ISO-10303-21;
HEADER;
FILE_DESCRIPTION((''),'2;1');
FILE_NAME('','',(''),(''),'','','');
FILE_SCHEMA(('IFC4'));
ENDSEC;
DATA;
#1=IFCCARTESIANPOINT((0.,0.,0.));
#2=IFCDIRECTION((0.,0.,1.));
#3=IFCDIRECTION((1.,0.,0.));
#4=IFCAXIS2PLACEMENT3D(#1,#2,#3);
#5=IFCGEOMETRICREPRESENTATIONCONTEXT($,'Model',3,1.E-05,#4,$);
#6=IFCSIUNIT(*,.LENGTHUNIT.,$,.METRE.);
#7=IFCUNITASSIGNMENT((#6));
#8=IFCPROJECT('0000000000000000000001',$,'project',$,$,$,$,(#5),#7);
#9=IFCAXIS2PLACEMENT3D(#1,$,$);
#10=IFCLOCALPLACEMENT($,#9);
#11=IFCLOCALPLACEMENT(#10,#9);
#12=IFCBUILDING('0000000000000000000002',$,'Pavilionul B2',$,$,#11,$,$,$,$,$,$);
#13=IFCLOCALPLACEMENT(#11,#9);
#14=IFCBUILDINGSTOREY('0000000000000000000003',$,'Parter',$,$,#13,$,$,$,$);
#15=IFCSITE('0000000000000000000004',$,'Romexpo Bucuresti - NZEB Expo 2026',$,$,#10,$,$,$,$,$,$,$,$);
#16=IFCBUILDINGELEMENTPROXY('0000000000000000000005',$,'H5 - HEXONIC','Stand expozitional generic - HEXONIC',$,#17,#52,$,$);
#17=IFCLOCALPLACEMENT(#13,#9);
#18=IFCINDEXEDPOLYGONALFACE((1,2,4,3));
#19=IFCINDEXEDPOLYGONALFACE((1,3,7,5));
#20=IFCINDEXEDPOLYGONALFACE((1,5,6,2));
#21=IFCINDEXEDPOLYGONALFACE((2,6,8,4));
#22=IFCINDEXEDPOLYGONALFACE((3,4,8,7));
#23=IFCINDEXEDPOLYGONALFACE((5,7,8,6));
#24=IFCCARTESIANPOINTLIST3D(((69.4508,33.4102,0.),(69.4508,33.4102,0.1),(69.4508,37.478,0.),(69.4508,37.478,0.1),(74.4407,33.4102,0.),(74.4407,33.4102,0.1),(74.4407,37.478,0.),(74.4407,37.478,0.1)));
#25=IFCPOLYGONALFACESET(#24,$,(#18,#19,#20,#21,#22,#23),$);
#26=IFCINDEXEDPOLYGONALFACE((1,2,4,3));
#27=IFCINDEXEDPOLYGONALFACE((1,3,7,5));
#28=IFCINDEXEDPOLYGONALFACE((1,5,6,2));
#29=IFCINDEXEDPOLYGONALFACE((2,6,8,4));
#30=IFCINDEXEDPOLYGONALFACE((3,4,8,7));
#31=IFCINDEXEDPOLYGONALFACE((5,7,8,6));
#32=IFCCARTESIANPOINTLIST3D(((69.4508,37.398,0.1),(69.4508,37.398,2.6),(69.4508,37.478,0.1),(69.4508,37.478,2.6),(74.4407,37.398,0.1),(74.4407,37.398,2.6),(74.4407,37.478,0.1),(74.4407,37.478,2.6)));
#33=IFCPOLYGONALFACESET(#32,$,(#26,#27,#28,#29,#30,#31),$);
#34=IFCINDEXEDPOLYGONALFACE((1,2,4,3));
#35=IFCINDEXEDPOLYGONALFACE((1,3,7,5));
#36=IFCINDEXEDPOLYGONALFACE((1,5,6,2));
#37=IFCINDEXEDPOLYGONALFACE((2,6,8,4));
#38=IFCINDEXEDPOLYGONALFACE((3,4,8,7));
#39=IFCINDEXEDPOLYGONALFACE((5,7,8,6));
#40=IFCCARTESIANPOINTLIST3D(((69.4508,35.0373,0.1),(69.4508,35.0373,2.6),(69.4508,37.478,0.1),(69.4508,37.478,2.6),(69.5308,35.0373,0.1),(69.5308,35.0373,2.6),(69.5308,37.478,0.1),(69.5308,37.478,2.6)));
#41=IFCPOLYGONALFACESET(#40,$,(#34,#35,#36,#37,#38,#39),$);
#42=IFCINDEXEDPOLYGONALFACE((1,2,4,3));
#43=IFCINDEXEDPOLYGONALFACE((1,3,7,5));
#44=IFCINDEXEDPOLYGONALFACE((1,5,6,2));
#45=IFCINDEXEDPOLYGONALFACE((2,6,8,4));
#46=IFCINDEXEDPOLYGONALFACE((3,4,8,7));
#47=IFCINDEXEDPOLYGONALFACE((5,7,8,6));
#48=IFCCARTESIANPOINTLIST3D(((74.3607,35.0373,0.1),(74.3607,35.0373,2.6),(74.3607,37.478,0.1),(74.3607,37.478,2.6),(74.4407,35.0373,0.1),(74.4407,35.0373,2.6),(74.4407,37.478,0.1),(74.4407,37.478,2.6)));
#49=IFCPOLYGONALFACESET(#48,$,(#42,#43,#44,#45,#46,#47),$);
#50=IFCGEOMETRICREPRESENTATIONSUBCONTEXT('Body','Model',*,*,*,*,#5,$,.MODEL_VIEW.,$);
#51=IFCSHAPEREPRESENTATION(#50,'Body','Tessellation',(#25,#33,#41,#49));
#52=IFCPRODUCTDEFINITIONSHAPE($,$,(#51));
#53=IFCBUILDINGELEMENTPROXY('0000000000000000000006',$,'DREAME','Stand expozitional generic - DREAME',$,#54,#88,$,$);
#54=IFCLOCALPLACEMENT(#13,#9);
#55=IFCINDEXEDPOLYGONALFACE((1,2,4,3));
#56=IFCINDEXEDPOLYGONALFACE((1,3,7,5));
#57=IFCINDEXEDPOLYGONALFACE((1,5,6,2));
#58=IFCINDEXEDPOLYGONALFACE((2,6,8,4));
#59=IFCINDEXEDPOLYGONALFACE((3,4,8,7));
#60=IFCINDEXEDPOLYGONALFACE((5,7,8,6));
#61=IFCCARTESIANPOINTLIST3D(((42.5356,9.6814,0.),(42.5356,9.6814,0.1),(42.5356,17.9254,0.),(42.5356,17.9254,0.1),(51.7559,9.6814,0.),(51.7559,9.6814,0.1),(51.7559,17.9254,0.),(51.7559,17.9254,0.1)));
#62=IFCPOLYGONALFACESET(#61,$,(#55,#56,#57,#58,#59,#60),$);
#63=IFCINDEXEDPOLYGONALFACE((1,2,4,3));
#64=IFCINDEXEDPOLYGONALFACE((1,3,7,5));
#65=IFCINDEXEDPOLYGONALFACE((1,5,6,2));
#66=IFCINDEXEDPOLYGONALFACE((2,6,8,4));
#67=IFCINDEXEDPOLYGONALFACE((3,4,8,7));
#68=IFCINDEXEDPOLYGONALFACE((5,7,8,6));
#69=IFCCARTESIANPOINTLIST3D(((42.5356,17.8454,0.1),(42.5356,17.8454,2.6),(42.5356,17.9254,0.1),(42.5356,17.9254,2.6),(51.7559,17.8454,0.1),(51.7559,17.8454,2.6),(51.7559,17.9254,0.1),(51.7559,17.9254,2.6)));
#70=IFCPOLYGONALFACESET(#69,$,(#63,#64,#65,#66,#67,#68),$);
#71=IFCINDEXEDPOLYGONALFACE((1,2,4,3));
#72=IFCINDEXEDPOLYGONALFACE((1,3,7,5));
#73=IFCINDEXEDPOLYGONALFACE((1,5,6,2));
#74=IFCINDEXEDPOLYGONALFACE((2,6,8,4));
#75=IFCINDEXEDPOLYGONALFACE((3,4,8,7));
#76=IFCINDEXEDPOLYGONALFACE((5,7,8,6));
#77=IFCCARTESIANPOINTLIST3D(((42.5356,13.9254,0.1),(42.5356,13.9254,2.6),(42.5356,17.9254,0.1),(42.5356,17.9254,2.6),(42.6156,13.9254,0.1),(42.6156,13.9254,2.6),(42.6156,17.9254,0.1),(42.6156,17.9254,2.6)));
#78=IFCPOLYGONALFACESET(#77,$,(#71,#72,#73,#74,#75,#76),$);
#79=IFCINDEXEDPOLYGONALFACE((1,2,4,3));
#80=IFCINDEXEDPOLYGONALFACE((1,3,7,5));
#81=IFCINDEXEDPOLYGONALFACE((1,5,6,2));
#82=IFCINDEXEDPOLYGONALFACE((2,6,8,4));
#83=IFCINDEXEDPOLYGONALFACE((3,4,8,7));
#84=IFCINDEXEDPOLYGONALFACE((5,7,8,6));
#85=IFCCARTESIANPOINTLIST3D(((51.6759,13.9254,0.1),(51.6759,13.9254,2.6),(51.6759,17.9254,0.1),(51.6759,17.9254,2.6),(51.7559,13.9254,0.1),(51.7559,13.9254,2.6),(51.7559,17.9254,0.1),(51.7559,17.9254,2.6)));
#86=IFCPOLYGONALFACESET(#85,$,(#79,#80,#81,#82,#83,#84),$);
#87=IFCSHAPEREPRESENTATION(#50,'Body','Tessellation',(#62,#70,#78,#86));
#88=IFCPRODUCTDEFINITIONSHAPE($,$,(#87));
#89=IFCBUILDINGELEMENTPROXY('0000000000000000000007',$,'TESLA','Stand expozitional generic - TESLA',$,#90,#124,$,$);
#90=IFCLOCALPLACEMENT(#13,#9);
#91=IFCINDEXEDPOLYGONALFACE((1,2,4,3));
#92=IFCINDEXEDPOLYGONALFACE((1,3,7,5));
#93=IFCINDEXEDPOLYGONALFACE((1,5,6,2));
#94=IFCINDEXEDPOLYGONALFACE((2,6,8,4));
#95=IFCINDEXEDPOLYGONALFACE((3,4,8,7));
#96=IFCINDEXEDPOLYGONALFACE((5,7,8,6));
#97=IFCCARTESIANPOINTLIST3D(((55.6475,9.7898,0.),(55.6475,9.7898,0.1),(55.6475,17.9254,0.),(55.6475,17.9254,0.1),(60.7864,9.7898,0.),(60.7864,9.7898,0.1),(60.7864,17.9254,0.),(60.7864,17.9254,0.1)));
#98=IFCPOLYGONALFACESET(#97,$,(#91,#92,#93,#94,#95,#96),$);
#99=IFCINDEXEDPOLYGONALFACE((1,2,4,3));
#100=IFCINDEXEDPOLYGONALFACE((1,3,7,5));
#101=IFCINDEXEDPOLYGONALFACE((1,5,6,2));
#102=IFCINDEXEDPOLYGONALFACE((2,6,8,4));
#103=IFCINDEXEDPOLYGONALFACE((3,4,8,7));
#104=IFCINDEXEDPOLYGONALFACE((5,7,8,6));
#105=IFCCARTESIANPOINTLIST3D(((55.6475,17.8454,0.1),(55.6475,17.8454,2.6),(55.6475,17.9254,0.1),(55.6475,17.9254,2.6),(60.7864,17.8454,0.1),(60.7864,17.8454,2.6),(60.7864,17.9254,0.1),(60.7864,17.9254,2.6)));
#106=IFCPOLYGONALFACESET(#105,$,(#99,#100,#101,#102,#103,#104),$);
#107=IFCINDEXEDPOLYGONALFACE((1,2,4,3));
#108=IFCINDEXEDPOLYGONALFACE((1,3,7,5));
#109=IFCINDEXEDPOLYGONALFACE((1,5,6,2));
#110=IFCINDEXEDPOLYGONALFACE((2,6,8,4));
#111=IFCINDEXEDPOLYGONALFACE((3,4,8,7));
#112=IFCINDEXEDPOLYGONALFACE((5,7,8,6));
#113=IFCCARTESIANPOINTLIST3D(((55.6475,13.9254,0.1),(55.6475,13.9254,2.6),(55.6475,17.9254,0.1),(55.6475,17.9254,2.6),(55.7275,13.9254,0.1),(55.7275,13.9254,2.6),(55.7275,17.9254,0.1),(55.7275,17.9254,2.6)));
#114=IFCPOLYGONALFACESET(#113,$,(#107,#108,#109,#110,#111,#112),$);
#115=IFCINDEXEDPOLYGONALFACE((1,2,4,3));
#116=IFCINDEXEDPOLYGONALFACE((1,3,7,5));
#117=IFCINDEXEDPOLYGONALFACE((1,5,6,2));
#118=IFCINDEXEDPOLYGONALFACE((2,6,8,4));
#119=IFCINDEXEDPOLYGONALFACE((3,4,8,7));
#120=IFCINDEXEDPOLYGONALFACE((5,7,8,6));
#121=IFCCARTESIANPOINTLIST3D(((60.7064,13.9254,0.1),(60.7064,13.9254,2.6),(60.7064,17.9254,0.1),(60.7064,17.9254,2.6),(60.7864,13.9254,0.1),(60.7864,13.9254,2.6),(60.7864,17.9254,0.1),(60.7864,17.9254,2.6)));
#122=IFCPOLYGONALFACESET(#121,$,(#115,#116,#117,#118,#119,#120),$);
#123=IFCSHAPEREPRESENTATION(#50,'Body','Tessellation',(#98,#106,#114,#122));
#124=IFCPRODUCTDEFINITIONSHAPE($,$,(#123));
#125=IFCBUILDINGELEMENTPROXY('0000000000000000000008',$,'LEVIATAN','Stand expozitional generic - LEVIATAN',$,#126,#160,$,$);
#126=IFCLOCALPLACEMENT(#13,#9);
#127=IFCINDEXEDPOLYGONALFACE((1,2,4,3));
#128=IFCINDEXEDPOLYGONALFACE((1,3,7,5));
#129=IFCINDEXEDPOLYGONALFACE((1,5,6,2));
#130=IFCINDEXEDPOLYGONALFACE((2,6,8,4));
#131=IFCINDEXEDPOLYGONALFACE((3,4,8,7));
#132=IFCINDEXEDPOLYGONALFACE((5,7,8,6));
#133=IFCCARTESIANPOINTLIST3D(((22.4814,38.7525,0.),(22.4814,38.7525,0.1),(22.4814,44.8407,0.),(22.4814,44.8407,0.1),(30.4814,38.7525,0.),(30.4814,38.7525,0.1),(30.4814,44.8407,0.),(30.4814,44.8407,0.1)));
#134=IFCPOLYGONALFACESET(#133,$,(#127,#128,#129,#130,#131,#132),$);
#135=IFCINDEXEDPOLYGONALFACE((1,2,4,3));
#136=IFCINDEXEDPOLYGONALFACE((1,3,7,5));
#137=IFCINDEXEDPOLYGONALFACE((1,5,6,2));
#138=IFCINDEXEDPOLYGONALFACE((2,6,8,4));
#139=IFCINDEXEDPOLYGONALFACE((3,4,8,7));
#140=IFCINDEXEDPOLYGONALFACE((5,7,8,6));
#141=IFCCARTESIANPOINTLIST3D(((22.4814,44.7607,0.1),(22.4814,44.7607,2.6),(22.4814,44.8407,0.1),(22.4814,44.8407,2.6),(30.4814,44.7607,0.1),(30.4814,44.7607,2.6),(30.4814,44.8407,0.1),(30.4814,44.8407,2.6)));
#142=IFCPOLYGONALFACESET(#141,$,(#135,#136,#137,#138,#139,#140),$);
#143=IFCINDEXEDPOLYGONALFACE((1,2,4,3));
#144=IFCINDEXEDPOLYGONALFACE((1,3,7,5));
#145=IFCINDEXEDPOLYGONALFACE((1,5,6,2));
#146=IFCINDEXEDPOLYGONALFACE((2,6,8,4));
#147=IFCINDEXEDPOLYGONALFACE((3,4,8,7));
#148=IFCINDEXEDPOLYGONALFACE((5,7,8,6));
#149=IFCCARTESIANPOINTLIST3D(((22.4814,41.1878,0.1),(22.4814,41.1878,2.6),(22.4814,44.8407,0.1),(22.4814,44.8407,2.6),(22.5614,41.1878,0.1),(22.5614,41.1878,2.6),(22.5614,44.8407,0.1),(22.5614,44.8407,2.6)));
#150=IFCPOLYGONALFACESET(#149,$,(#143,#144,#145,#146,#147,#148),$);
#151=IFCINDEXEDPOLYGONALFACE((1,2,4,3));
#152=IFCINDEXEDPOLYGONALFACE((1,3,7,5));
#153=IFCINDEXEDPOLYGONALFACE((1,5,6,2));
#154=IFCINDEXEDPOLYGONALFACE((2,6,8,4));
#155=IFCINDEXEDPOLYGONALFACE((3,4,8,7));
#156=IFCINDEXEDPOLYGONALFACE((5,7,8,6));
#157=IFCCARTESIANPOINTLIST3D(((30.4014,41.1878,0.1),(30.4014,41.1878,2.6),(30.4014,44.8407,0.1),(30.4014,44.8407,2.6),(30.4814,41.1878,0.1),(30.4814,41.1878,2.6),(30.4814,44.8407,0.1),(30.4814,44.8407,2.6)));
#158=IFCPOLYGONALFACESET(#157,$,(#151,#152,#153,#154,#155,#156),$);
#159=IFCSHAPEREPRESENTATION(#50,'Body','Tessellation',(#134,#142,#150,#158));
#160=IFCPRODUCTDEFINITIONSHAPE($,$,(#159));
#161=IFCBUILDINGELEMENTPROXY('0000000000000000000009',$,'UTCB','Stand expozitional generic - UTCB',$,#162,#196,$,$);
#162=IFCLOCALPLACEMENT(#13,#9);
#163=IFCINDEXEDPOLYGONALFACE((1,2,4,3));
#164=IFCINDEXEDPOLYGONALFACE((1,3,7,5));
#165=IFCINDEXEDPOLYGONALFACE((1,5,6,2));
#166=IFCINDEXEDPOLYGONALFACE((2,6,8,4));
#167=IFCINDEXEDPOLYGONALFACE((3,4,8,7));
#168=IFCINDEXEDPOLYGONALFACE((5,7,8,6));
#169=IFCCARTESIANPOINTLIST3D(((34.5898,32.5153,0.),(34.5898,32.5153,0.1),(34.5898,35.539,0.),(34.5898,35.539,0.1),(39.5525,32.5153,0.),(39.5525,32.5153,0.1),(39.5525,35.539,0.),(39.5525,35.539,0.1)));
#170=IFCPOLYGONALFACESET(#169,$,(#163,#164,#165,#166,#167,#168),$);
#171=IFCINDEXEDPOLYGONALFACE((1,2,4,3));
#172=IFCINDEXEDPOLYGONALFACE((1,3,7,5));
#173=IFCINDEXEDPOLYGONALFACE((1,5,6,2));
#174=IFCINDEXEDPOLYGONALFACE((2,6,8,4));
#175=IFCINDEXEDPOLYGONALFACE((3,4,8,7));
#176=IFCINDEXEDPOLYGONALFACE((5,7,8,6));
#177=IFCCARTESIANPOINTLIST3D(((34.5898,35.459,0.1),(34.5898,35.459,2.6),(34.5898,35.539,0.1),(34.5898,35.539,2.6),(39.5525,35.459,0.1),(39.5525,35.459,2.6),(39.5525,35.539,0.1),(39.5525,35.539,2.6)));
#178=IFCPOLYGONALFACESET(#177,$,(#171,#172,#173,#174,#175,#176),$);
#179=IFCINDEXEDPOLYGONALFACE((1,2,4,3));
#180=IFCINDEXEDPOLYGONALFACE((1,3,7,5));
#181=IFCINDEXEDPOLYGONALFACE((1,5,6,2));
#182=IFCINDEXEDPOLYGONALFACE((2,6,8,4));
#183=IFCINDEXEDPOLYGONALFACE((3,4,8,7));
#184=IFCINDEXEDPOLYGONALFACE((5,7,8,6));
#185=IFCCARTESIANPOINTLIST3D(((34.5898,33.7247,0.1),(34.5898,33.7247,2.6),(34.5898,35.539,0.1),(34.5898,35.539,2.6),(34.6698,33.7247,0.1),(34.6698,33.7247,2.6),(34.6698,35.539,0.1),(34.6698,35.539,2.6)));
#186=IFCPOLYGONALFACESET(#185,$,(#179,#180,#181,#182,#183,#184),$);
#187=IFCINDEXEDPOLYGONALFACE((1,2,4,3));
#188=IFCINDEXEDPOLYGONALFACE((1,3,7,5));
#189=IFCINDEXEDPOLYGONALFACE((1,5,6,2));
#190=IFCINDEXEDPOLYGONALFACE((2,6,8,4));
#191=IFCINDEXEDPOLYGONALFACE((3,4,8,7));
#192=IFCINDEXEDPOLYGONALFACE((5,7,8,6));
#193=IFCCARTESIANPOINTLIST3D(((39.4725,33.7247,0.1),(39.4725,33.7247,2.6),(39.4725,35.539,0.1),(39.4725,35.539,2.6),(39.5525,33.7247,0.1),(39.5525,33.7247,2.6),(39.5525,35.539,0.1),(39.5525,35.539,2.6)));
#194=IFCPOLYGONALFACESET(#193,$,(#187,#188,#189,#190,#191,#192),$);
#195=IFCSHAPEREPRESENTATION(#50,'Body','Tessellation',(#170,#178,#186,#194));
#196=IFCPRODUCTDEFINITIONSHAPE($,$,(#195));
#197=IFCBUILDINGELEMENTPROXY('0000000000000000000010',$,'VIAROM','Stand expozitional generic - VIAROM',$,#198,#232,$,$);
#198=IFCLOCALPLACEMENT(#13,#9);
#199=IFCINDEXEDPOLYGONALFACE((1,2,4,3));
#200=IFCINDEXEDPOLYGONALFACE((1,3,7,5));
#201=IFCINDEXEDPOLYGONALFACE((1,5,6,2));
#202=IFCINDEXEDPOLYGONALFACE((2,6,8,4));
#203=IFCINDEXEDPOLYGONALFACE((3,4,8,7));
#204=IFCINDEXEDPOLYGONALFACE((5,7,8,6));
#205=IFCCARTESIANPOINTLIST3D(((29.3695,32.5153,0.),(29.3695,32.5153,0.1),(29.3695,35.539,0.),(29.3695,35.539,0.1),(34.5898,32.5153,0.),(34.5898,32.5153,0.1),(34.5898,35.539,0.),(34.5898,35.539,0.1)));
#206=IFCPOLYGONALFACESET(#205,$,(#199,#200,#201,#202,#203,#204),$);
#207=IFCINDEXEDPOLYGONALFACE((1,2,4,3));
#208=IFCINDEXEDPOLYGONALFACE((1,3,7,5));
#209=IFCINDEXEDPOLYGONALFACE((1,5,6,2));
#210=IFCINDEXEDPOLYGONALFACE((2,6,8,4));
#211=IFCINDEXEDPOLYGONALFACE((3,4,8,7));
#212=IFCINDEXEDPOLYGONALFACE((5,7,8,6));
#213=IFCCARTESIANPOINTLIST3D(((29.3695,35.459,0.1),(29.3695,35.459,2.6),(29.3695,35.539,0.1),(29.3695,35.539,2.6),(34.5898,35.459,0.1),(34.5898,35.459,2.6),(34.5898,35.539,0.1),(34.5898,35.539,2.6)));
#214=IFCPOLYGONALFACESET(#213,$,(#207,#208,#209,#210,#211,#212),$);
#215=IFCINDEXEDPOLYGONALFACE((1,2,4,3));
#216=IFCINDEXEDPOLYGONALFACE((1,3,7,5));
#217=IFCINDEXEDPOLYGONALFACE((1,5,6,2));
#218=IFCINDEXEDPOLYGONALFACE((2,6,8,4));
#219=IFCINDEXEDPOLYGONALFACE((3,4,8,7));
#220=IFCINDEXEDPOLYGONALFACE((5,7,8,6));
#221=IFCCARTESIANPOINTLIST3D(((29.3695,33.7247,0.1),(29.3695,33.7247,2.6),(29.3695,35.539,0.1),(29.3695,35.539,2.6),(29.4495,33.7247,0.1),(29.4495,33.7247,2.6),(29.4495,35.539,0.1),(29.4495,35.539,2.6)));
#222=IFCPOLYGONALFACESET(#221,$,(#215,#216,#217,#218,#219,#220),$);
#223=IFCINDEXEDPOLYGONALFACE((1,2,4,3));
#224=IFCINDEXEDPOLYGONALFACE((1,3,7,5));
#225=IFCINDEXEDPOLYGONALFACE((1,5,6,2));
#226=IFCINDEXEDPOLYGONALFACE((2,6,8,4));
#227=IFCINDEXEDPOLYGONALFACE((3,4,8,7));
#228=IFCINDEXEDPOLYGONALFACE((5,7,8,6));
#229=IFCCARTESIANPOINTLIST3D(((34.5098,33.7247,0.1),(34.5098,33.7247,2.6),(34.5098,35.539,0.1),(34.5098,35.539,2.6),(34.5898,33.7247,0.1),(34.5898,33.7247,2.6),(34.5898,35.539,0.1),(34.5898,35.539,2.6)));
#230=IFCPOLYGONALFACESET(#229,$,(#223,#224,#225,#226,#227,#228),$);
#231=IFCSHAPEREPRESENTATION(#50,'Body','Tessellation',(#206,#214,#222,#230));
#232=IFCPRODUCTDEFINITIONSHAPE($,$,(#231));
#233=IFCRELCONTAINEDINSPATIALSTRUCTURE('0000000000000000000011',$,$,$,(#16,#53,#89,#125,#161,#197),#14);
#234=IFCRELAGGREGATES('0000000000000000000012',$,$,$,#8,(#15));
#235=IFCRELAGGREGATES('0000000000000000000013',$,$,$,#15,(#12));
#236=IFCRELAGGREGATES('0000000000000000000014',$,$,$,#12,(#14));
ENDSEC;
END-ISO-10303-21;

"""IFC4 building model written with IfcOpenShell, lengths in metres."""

from ifc_helpers import new_model, si_unit, frame, frame_2d, origin, origin_with_axes, place, context, subcontext, project, spatial, rectangle, extrude, element, save


model = new_model("IFC4")

# Units and contexts
model_context = context("Model", 3, precision=1e-05, world=origin_with_axes())
body_context = subcontext(model_context, "Body", "Model", "MODEL_VIEW")
ifc_project = project(units=[si_unit("LENGTHUNIT", "METRE")], contexts=[model_context])

# Site, building, storey
site_placement = place(None, origin())
site = spatial("IfcSite", under=ifc_project, at=site_placement, Name="Romexpo Bucuresti - NZEB Expo 2026")
building_placement = place(site_placement, origin())
building = spatial("IfcBuilding", under=site, at=building_placement, Name="Pavilionul B2")
storey_placement = place(building_placement, origin())
storey = spatial("IfcBuildingStorey", under=building, at=storey_placement, Name="Parter")

# Building element proxies
proxy_1_placement = place(storey_placement, frame((69.4508, 33.4102, 0.0), z_axis=(0.0, 0.0, 1.0), x_axis=(1.0, 0.0, 0.0)))
element("IfcBuildingElementProxy", 1, at=proxy_1_placement, inside=storey, Name="H5 - HEXONIC", Description="Stand expozitional generic - HEXONIC", context=body_context, shape_type="SweptSolid", body=[
    extrude(rectangle(XDim=4.9898, YDim=4.0678, at=frame_2d((2.4949, 2.0339))), origin(), (0.0, 0.0, 1.0), 0.1),
    extrude(rectangle(XDim=4.9898, YDim=0.08, at=frame_2d((2.4949, 4.0278))), frame((0.0, 0.0, 0.1)), (0.0, 0.0, 1.0), 2.5),
    extrude(rectangle(XDim=0.08, YDim=2.4407, at=frame_2d((0.04, 2.8475))), frame((0.0, 0.0, 0.1)), (0.0, 0.0, 1.0), 2.5),
    extrude(rectangle(XDim=0.08, YDim=2.4407, at=frame_2d((4.9498, 2.8475))), frame((0.0, 0.0, 0.1)), (0.0, 0.0, 1.0), 2.5),
])
proxy_2_placement = place(storey_placement, frame((42.5356, 9.6814, 0.0), z_axis=(0.0, 0.0, 1.0), x_axis=(1.0, 0.0, 0.0)))
element("IfcBuildingElementProxy", 2, at=proxy_2_placement, inside=storey, Name="DREAME", Description="Stand expozitional generic - DREAME", context=body_context, shape_type="SweptSolid", body=[
    extrude(rectangle(XDim=9.2203, YDim=8.2441, at=frame_2d((4.6102, 4.122))), origin(), (0.0, 0.0, 1.0), 0.1),
    extrude(rectangle(XDim=9.2203, YDim=0.08, at=frame_2d((4.6102, 8.2041))), frame((0.0, 0.0, 0.1)), (0.0, 0.0, 1.0), 2.5),
    extrude(rectangle(XDim=0.08, YDim=4.0, at=frame_2d((0.04, 6.2441))), frame((0.0, 0.0, 0.1)), (0.0, 0.0, 1.0), 2.5),
    extrude(rectangle(XDim=0.08, YDim=4.0, at=frame_2d((9.1803, 6.2441))), frame((0.0, 0.0, 0.1)), (0.0, 0.0, 1.0), 2.5),
])
proxy_3_placement = place(storey_placement, frame((55.6475, 9.7898, 0.0), z_axis=(0.0, 0.0, 1.0), x_axis=(1.0, 0.0, 0.0)))
element("IfcBuildingElementProxy", 3, at=proxy_3_placement, inside=storey, Name="TESLA", Description="Stand expozitional generic - TESLA", context=body_context, shape_type="SweptSolid", body=[
    extrude(rectangle(XDim=5.139, YDim=8.1356, at=frame_2d((2.5695, 4.0678))), origin(), (0.0, 0.0, 1.0), 0.1),
    extrude(rectangle(XDim=5.139, YDim=0.08, at=frame_2d((2.5695, 8.0956))), frame((0.0, 0.0, 0.1)), (0.0, 0.0, 1.0), 2.5),
    extrude(rectangle(XDim=0.08, YDim=4.0, at=frame_2d((0.04, 6.1356))), frame((0.0, 0.0, 0.1)), (0.0, 0.0, 1.0), 2.5),
    extrude(rectangle(XDim=0.08, YDim=4.0, at=frame_2d((5.099, 6.1356))), frame((0.0, 0.0, 0.1)), (0.0, 0.0, 1.0), 2.5),
])
proxy_4_placement = place(storey_placement, frame((22.4814, 38.7525, 0.0), z_axis=(0.0, 0.0, 1.0), x_axis=(1.0, 0.0, 0.0)))
element("IfcBuildingElementProxy", 4, at=proxy_4_placement, inside=storey, Name="LEVIATAN", Description="Stand expozitional generic - LEVIATAN", context=body_context, shape_type="SweptSolid", body=[
    extrude(rectangle(XDim=8.0, YDim=6.0881, at=frame_2d((4.0, 3.0441))), origin(), (0.0, 0.0, 1.0), 0.1),
    extrude(rectangle(XDim=8.0, YDim=0.08, at=frame_2d((4.0, 6.0481))), frame((0.0, 0.0, 0.1)), (0.0, 0.0, 1.0), 2.5),
    extrude(rectangle(XDim=0.08, YDim=3.6529, at=frame_2d((0.04, 4.2617))), frame((0.0, 0.0, 0.1)), (0.0, 0.0, 1.0), 2.5),
    extrude(rectangle(XDim=0.08, YDim=3.6529, at=frame_2d((7.96, 4.2617))), frame((0.0, 0.0, 0.1)), (0.0, 0.0, 1.0), 2.5),
])
proxy_5_placement = place(storey_placement, frame((34.5898, 32.5153, 0.0), z_axis=(0.0, 0.0, 1.0), x_axis=(1.0, 0.0, 0.0)))
element("IfcBuildingElementProxy", 5, at=proxy_5_placement, inside=storey, Name="UTCB", Description="Stand expozitional generic - UTCB", context=body_context, shape_type="SweptSolid", body=[
    extrude(rectangle(XDim=4.9627, YDim=3.0237, at=frame_2d((2.4814, 1.5119))), origin(), (0.0, 0.0, 1.0), 0.1),
    extrude(rectangle(XDim=4.9627, YDim=0.08, at=frame_2d((2.4814, 2.9837))), frame((0.0, 0.0, 0.1)), (0.0, 0.0, 1.0), 2.5),
    extrude(rectangle(XDim=0.08, YDim=1.8142, at=frame_2d((0.04, 2.1166))), frame((0.0, 0.0, 0.1)), (0.0, 0.0, 1.0), 2.5),
    extrude(rectangle(XDim=0.08, YDim=1.8142, at=frame_2d((4.9227, 2.1166))), frame((0.0, 0.0, 0.1)), (0.0, 0.0, 1.0), 2.5),
])
proxy_6_placement = place(storey_placement, frame((29.3695, 32.5153, 0.0), z_axis=(0.0, 0.0, 1.0), x_axis=(1.0, 0.0, 0.0)))
element("IfcBuildingElementProxy", 6, at=proxy_6_placement, inside=storey, Name="VIAROM", Description="Stand expozitional generic - VIAROM", context=body_context, shape_type="SweptSolid", body=[
    extrude(rectangle(XDim=5.2203, YDim=3.0237, at=frame_2d((2.6102, 1.5119))), origin(), (0.0, 0.0, 1.0), 0.1),
    extrude(rectangle(XDim=5.2203, YDim=0.08, at=frame_2d((2.6102, 2.9837))), frame((0.0, 0.0, 0.1)), (0.0, 0.0, 1.0), 2.5),
    extrude(rectangle(XDim=0.08, YDim=1.8142, at=frame_2d((0.04, 2.1166))), frame((0.0, 0.0, 0.1)), (0.0, 0.0, 1.0), 2.5),
    extrude(rectangle(XDim=0.08, YDim=1.8142, at=frame_2d((5.1803, 2.1166))), frame((0.0, 0.0, 0.1)), (0.0, 0.0, 1.0), 2.5),
])

save(model, "model.ifc")
